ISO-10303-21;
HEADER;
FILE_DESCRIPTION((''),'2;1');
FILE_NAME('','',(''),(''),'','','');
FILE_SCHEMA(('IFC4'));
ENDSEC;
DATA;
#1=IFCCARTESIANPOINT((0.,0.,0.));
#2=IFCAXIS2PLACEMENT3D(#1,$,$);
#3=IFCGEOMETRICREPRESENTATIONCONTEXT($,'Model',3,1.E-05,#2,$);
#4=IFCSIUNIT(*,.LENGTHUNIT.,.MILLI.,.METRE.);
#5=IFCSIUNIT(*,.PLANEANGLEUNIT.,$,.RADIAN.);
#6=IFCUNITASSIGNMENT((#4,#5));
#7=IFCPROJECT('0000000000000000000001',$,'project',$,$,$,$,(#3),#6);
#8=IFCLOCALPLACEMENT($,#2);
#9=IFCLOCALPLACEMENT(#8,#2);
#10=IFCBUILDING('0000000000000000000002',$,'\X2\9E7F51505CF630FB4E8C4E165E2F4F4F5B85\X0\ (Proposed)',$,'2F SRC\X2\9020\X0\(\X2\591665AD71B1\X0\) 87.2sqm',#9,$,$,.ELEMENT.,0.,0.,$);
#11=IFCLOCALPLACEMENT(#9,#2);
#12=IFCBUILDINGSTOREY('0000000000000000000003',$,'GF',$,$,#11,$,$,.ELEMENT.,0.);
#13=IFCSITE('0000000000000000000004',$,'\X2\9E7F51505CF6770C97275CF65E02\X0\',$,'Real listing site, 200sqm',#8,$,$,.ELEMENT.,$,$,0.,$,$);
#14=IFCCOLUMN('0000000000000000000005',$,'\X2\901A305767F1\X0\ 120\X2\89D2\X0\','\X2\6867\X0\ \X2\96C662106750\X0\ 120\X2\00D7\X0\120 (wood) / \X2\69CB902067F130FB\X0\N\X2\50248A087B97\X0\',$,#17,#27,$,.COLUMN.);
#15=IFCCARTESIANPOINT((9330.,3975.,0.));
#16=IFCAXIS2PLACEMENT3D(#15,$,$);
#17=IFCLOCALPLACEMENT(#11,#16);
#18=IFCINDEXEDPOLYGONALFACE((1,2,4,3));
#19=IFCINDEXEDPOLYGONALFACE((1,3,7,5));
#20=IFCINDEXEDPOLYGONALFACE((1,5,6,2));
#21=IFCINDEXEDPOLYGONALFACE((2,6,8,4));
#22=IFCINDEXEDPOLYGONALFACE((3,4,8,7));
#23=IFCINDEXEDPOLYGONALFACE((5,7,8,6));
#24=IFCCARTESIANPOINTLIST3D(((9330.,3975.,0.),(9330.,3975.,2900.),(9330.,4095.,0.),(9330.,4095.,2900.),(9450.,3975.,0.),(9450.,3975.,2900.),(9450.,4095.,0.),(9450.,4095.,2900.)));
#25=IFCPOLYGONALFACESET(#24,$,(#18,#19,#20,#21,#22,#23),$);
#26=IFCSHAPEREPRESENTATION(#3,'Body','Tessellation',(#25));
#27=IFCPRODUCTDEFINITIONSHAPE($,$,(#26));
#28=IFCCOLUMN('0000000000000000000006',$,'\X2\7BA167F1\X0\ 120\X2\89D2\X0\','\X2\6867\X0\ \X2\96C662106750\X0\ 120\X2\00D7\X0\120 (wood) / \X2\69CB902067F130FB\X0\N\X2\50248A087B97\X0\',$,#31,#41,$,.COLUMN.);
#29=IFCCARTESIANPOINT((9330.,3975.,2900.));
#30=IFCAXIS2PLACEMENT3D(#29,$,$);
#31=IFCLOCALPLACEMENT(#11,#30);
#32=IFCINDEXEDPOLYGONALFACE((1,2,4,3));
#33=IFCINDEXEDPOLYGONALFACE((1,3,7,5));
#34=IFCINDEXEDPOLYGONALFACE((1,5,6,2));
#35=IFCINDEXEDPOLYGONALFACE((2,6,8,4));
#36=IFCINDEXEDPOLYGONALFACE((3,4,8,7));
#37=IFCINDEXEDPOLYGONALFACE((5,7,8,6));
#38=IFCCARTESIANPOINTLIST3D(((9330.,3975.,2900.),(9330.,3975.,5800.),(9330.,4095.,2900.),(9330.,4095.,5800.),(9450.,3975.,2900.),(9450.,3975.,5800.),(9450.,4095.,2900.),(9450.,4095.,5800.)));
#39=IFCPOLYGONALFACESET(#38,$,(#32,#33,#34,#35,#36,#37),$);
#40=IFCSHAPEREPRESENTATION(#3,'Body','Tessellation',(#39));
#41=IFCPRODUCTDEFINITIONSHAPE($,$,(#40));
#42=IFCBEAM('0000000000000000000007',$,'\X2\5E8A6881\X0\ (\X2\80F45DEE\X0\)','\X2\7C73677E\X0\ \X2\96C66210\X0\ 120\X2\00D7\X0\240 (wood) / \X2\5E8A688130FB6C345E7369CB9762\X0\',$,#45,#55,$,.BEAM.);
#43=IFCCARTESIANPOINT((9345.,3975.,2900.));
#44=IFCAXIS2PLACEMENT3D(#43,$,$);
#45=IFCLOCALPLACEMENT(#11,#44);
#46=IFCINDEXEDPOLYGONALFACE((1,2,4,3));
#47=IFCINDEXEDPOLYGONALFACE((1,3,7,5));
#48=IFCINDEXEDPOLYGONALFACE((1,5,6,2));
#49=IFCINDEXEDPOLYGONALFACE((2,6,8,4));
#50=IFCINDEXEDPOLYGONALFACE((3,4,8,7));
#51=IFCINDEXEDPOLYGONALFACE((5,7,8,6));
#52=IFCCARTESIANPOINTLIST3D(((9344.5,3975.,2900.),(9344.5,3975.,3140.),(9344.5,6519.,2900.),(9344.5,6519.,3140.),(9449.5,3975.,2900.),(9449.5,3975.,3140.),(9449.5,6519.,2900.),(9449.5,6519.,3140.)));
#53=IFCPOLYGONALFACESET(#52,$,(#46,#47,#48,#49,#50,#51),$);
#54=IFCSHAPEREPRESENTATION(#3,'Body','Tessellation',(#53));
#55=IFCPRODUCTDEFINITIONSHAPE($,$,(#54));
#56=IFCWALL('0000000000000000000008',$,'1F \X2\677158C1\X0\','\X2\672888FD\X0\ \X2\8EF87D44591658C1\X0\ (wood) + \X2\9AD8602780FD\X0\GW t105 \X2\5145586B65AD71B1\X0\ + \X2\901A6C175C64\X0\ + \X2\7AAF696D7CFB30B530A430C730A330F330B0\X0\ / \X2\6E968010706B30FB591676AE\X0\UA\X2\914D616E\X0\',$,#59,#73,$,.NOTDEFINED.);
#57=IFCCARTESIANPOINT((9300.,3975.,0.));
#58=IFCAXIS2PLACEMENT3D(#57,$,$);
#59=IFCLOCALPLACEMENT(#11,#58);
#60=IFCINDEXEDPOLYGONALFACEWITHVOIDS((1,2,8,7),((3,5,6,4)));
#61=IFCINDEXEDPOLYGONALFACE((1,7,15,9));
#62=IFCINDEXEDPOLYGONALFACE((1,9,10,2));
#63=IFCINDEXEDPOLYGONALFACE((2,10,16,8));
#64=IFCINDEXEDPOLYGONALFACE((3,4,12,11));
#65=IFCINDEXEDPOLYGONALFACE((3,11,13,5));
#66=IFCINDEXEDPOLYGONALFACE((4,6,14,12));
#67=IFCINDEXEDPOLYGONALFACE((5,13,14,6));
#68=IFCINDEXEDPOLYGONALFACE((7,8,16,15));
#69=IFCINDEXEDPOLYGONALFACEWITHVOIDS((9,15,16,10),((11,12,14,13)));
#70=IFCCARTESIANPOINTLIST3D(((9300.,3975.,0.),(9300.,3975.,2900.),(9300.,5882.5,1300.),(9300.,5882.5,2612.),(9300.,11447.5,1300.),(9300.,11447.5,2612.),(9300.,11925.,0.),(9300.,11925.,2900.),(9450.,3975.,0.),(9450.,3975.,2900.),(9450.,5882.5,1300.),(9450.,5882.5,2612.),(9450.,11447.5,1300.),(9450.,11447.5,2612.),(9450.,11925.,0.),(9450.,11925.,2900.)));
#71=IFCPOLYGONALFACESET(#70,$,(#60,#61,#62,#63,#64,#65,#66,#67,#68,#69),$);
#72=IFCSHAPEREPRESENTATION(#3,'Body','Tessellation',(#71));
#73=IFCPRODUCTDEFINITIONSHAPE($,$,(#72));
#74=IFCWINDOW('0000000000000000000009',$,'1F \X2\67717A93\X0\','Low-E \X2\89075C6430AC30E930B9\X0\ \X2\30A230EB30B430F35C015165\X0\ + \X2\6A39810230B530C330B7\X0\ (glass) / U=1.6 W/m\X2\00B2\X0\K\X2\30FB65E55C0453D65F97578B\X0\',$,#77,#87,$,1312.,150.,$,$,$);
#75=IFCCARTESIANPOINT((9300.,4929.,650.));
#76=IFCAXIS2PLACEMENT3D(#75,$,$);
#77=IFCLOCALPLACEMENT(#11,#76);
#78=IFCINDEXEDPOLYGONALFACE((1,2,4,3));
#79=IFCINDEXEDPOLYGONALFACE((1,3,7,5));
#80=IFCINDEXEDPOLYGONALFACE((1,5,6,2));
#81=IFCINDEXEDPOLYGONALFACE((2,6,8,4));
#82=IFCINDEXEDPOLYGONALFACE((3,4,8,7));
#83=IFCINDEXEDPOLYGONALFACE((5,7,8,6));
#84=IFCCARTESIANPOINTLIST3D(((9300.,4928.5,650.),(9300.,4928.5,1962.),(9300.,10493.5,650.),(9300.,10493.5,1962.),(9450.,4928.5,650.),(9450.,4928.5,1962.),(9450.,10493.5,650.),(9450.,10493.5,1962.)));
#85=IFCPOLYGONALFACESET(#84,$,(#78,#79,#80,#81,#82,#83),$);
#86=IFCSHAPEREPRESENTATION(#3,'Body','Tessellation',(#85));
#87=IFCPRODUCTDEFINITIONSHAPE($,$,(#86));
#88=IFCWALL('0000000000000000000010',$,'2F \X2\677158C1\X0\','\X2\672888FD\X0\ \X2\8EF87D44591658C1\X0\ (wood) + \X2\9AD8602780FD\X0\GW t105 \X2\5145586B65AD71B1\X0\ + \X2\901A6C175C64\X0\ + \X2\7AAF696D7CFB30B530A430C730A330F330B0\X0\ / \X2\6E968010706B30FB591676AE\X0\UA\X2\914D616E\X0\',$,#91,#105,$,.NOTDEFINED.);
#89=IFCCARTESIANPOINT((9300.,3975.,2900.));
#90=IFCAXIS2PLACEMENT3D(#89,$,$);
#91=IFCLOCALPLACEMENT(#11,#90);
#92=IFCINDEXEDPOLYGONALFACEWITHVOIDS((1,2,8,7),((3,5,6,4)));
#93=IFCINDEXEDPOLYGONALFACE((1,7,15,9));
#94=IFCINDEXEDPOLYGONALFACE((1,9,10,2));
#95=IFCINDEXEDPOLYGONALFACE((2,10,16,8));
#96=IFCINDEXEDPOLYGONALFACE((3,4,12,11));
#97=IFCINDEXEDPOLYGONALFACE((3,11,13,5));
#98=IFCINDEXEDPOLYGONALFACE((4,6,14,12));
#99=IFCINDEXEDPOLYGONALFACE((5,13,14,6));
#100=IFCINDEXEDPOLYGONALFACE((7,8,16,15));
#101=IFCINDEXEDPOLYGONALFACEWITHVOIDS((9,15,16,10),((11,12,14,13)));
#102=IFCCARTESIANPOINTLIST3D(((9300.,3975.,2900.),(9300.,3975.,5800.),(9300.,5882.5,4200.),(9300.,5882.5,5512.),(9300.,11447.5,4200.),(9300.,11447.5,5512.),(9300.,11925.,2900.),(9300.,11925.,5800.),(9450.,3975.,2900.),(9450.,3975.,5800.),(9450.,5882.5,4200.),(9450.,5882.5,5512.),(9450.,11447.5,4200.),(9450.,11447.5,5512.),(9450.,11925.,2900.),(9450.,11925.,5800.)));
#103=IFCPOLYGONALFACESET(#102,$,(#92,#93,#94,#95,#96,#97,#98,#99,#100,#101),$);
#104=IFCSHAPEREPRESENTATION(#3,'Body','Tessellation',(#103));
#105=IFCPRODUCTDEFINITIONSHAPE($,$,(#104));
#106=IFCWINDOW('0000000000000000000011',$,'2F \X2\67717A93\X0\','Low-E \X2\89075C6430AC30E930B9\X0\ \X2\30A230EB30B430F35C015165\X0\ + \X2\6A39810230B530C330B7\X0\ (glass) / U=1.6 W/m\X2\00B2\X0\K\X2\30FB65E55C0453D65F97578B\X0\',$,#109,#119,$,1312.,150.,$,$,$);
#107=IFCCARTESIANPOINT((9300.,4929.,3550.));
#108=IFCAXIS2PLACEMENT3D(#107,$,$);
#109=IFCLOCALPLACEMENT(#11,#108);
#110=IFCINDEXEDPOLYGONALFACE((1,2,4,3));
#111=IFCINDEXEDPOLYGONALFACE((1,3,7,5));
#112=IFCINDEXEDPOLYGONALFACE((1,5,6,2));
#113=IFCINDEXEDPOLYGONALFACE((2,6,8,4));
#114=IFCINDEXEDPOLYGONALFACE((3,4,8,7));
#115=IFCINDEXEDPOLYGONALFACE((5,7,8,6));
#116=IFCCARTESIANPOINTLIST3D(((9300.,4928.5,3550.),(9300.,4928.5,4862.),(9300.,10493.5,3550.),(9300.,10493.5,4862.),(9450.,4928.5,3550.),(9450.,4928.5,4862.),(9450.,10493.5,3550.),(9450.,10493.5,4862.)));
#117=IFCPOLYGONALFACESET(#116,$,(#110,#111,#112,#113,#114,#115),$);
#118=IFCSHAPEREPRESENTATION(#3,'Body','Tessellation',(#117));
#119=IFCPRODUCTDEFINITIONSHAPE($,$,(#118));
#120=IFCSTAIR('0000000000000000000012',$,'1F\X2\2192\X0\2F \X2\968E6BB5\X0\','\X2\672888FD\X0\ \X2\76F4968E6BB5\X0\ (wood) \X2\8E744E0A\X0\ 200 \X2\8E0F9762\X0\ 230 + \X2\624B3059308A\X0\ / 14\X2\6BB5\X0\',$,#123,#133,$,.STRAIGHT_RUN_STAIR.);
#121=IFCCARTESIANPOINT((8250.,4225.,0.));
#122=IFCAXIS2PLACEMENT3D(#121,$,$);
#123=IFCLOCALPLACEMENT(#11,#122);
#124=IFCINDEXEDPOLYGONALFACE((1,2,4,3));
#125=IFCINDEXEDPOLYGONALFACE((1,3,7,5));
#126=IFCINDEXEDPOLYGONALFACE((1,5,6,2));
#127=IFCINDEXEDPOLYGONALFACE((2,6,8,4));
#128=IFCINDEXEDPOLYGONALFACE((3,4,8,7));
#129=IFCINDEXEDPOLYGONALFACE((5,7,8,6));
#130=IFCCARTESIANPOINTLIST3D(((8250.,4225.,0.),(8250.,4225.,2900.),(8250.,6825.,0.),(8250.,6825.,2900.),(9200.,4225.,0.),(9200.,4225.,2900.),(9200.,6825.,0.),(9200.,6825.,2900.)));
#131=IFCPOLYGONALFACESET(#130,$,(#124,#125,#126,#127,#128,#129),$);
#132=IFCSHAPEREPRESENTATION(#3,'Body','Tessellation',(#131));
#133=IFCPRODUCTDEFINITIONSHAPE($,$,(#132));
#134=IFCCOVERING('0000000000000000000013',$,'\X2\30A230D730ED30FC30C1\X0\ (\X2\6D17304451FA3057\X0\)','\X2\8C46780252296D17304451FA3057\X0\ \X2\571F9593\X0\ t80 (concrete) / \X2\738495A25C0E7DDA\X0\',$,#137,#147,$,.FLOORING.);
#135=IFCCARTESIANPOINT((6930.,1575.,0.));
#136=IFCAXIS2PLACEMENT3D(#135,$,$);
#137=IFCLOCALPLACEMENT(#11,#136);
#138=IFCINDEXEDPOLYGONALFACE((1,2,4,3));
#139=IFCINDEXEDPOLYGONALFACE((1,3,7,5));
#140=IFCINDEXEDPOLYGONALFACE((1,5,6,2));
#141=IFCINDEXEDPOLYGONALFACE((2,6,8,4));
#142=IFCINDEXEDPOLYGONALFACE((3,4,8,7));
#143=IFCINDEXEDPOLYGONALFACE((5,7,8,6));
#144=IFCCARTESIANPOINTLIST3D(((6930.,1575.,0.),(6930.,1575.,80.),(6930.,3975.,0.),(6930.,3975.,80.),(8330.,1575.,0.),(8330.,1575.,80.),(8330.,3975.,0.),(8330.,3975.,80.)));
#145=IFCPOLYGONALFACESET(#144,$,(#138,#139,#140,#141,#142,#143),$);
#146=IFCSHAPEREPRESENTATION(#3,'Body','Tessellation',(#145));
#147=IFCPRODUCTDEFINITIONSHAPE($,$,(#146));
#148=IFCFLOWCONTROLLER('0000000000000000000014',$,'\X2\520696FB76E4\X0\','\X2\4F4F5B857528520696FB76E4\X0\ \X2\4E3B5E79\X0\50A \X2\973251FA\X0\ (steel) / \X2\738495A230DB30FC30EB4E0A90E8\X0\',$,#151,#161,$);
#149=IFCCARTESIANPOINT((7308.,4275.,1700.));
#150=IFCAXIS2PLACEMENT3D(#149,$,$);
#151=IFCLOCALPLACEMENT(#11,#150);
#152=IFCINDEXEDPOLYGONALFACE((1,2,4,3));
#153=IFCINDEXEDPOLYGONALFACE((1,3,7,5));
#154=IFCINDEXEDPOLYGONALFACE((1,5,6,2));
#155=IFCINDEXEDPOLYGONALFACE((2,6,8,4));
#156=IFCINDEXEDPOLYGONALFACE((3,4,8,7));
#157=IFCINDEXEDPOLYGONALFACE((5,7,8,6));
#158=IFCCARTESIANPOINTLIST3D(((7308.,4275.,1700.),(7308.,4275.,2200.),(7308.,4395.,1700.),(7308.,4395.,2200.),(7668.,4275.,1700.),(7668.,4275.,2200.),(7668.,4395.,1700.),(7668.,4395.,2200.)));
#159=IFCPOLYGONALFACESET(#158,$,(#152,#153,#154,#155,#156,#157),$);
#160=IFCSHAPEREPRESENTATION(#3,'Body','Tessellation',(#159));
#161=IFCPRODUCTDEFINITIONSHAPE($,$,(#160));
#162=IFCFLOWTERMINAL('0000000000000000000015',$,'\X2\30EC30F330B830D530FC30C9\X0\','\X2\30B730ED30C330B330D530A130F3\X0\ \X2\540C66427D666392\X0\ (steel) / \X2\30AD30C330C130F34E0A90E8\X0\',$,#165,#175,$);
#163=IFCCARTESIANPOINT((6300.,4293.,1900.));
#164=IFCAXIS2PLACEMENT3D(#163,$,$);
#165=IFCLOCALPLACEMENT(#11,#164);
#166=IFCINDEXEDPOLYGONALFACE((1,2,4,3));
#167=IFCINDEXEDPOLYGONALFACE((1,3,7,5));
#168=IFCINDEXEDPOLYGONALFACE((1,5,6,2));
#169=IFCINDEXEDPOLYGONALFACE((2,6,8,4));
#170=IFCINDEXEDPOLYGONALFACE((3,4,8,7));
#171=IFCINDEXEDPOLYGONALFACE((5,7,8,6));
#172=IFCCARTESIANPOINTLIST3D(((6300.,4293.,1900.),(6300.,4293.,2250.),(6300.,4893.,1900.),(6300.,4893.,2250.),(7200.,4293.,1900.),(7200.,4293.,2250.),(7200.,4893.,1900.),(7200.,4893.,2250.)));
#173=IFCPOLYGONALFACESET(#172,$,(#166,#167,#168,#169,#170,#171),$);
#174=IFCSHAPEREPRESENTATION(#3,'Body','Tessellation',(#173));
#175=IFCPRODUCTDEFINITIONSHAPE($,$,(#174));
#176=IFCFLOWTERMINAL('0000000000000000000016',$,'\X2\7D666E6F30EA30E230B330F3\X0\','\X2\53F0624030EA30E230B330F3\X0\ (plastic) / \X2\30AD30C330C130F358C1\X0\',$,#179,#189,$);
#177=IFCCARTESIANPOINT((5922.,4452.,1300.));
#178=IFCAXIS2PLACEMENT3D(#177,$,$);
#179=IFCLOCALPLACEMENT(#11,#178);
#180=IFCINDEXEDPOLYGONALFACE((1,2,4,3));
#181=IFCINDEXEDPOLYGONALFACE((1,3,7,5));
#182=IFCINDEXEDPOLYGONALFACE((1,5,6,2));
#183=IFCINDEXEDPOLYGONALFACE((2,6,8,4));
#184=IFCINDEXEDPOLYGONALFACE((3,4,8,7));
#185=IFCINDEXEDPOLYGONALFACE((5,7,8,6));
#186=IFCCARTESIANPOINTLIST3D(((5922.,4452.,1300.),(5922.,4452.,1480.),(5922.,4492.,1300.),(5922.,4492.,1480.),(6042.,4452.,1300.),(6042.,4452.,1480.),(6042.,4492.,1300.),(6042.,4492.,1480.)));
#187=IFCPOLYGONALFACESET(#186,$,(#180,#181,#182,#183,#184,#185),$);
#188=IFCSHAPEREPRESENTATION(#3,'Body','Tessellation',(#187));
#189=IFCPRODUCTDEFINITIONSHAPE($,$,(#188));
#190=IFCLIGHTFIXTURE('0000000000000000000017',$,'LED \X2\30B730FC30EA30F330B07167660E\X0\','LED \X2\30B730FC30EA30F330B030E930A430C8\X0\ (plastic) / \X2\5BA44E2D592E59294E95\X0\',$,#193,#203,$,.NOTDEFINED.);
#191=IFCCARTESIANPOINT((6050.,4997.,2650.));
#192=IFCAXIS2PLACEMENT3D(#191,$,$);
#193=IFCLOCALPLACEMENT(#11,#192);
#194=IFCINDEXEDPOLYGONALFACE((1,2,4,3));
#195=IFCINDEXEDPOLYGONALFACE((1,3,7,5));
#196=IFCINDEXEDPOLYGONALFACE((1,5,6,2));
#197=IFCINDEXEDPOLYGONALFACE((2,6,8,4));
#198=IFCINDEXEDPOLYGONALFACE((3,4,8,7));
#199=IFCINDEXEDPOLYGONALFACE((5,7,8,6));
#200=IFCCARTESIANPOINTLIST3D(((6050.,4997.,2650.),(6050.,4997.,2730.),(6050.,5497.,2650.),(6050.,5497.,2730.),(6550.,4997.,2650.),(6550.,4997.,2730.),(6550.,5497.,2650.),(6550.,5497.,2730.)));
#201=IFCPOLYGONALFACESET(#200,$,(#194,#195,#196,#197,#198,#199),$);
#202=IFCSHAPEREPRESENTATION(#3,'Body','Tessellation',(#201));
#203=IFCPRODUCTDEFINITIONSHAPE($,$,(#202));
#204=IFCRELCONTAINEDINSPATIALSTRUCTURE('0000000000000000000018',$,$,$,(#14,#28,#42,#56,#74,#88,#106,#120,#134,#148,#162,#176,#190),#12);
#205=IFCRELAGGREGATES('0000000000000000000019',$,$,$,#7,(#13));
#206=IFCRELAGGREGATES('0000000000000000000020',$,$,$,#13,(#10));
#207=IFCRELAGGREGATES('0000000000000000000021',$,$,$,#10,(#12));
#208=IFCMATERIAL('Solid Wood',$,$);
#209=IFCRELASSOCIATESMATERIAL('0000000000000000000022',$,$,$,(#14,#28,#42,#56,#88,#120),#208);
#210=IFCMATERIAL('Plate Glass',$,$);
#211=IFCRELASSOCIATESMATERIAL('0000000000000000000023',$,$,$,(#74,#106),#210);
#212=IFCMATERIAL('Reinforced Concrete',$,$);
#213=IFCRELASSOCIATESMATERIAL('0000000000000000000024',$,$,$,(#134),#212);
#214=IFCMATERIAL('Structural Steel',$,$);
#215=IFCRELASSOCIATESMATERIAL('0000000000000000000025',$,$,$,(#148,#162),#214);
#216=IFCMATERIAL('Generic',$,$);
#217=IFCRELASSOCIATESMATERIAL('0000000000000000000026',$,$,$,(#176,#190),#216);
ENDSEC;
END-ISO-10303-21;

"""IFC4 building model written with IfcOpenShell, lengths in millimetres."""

from ifc_helpers import new_model, si_unit, frame, frame_2d, origin, place, context, project, spatial, rectangle, extrude, material, element, fill, save


model = new_model("IFC4")

# Units and contexts
model_context = context("Model", 3, precision=1e-05, world=origin())
ifc_project = project(units=[si_unit("LENGTHUNIT", "METRE", prefix="MILLI"), si_unit("PLANEANGLEUNIT", "RADIAN")], contexts=[model_context])

# Site, building, storey
site_placement = place(None, origin())
site = spatial("IfcSite", under=ifc_project, at=site_placement, Name="鹿児島県霧島市", ObjectType="Real listing site, 200sqm", CompositionType="ELEMENT", RefElevation=0.0)
building_placement = place(site_placement, origin())
building = spatial("IfcBuilding", under=site, at=building_placement, Name="鹿児島・二世帯住宅 (Proposed)", ObjectType="2F SRC造(外断熱) 87.2sqm", CompositionType="ELEMENT", ElevationOfRefHeight=0.0, ElevationOfTerrain=0.0)
storey_placement = place(building_placement, origin())
storey = spatial("IfcBuildingStorey", under=building, at=storey_placement, Name="GF", CompositionType="ELEMENT", Elevation=0.0)

# Columns
ifc_material_1 = material(Name="Solid Wood")
column_1_placement = place(storey_placement, frame((9330.0, 3975.0, 0.0)))
element("IfcColumn", 1, at=column_1_placement, inside=storey, material=ifc_material_1, Name="通し柱 120角", Description="桧 集成材 120×120 (wood) / 構造柱・N値計算", PredefinedType="COLUMN", context=model_context, shape_type="SweptSolid", body=[
    extrude(rectangle(XDim=120.0, YDim=120.0, at=frame_2d((60.0, 60.0))), frame((9330.0, 3975.0, 0.0)), (0.0, 0.0, 1.0), 2900.0),
])
column_2_placement = place(storey_placement, frame((9330.0, 3975.0, 2900.0)))
element("IfcColumn", 2, at=column_2_placement, inside=storey, material=ifc_material_1, Name="管柱 120角", Description="桧 集成材 120×120 (wood) / 構造柱・N値計算", PredefinedType="COLUMN", context=model_context, shape_type="SweptSolid", body=[
    extrude(rectangle(XDim=120.0, YDim=120.0, at=frame_2d((60.0, 60.0))), frame((9330.0, 3975.0, 2900.0)), (0.0, 0.0, 1.0), 2900.0),
])

# Beam
beam_1_placement = place(storey_placement, frame((9345.0, 3975.0, 2900.0)))
element("IfcBeam", 3, at=beam_1_placement, inside=storey, material=ifc_material_1, Name="床梁 (胴差)", Description="米松 集成 120×240 (wood) / 床梁・水平構面", PredefinedType="BEAM", context=model_context, shape_type="SweptSolid", body=[
    extrude(rectangle(XDim=105.0, YDim=2544.0, at=frame_2d((52.0, 1272.0))), frame((9345.0, 3975.0, 2900.0)), (0.0, 0.0, 1.0), 240.0),
])

# Wall, opening, window
wall_1_placement = place(storey_placement, frame((9300.0, 3975.0, 0.0)))
wall_1 = element("IfcWall", 4, at=wall_1_placement, inside=storey, material=ifc_material_1, Name="1F 東壁", Description="木製 軸組外壁 (wood) + 高性能GW t105 充填断熱 + 通気層 + 窯業系サイディング / 準耐火・外皮UA配慮", PredefinedType="NOTDEFINED", context=model_context, shape_type="SweptSolid", body=[
    extrude(rectangle(XDim=150.0, YDim=7950.0, at=frame_2d((75.0, 3975.0))), frame((9300.0, 3975.0, 0.0)), (0.0, 0.0, 1.0), 2900.0),
])
opening_1_placement = place(storey_placement, frame((9300.0, 4929.0, 650.0)))
opening_1 = element("IfcOpeningElement", 5, at=opening_1_placement, cuts=wall_1, PredefinedType="NOTDEFINED", context=model_context, shape_type="SweptSolid", body=[
    extrude(rectangle(XDim=150.0, YDim=5565.0, at=frame_2d((75.0, 2782.0))), frame((9300.0, 4929.0, 650.0)), (0.0, 0.0, 1.0), 1312.0),
])
ifc_material_2 = material(Name="Plate Glass")
window_1_placement = place(storey_placement, frame((9300.0, 4929.0, 650.0)))
window_1 = element("IfcWindow", 6, at=window_1_placement, inside=storey, material=ifc_material_2, Name="1F 東窓", Description="Low-E 複層ガラス アルゴン封入 + 樹脂サッシ (glass) / U=1.6 W/m²K・日射取得型", OverallHeight=1312.0, OverallWidth=150.0, context=model_context, shape_type="SweptSolid", body=[
    extrude(rectangle(XDim=150.0, YDim=5565.0, at=frame_2d((75.0, 2782.0))), frame((9300.0, 4929.0, 650.0)), (0.0, 0.0, 1.0), 1312.0),
])
fill(opening_1, window_1)

# Wall, opening, window
wall_2_placement = place(storey_placement, frame((9300.0, 3975.0, 2900.0)))
wall_2 = element("IfcWall", 7, at=wall_2_placement, inside=storey, material=ifc_material_1, Name="2F 東壁", Description="木製 軸組外壁 (wood) + 高性能GW t105 充填断熱 + 通気層 + 窯業系サイディング / 準耐火・外皮UA配慮", PredefinedType="NOTDEFINED", context=model_context, shape_type="SweptSolid", body=[
    extrude(rectangle(XDim=150.0, YDim=7950.0, at=frame_2d((75.0, 3975.0))), frame((9300.0, 3975.0, 2900.0)), (0.0, 0.0, 1.0), 2900.0),
])
opening_2_placement = place(storey_placement, frame((9300.0, 4929.0, 3550.0)))
opening_2 = element("IfcOpeningElement", 8, at=opening_2_placement, cuts=wall_2, PredefinedType="NOTDEFINED", context=model_context, shape_type="SweptSolid", body=[
    extrude(rectangle(XDim=150.0, YDim=5565.0, at=frame_2d((75.0, 2782.0))), frame((9300.0, 4929.0, 3550.0)), (0.0, 0.0, 1.0), 1312.0),
])
window_2_placement = place(storey_placement, frame((9300.0, 4929.0, 3550.0)))
window_2 = element("IfcWindow", 9, at=window_2_placement, inside=storey, material=ifc_material_2, Name="2F 東窓", Description="Low-E 複層ガラス アルゴン封入 + 樹脂サッシ (glass) / U=1.6 W/m²K・日射取得型", OverallHeight=1312.0, OverallWidth=150.0, context=model_context, shape_type="SweptSolid", body=[
    extrude(rectangle(XDim=150.0, YDim=5565.0, at=frame_2d((75.0, 2782.0))), frame((9300.0, 4929.0, 3550.0)), (0.0, 0.0, 1.0), 1312.0),
])
fill(opening_2, window_2)

# Stair
stair_placement = place(storey_placement, frame((8250.0, 4225.0, 0.0)))
element("IfcStair", 10, at=stair_placement, inside=storey, material=ifc_material_1, Name="1F→2F 階段", Description="木製 直階段 (wood) 蹴上 200 踏面 230 + 手すり / 14段", PredefinedType="STRAIGHT_RUN_STAIR", context=model_context, shape_type="SweptSolid", body=[
    extrude(rectangle(XDim=950.0, YDim=2600.0, at=frame_2d((475.0, 1300.0))), frame((8250.0, 4225.0, 0.0)), (0.0, 0.0, 1.0), 2900.0),
])

# Covering
ifc_material_3 = material(Name="Reinforced Concrete")
covering_placement = place(storey_placement, frame((6930.0, 1575.0, 0.0)))
element("IfcCovering", 11, at=covering_placement, inside=storey, material=ifc_material_3, Name="アプローチ (洗い出し)", Description="豆砂利洗い出し 土間 t80 (concrete) / 玄関導線", PredefinedType="FLOORING", context=model_context, shape_type="SweptSolid", body=[
    extrude(rectangle(XDim=1400.0, YDim=2400.0, at=frame_2d((700.0, 1200.0))), frame((6930.0, 1575.0, 0.0)), (0.0, 0.0, 1.0), 80.0),
])

# Flow controller
ifc_material_4 = material(Name="Structural Steel")
flow_controller_placement = place(storey_placement, frame((7308.0, 4275.0, 1700.0)))
element("IfcFlowController", 12, at=flow_controller_placement, inside=storey, material=ifc_material_4, Name="分電盤", Description="住宅用分電盤 主幹50A 露出 (steel) / 玄関ホール上部", context=model_context, shape_type="SweptSolid", body=[
    extrude(rectangle(XDim=360.0, YDim=120.0, at=frame_2d((180.0, 60.0))), frame((7308.0, 4275.0, 1700.0)), (0.0, 0.0, 1.0), 500.0),
])

# Flow terminals
flow_terminal_1_placement = place(storey_placement, frame((6300.0, 4293.0, 1900.0)))
element("IfcFlowTerminal", 13, at=flow_terminal_1_placement, inside=storey, material=ifc_material_4, Name="レンジフード", Description="シロッコファン 同時給排 (steel) / キッチン上部", context=model_context, shape_type="SweptSolid", body=[
    extrude(rectangle(XDim=900.0, YDim=600.0, at=frame_2d((450.0, 300.0))), frame((6300.0, 4293.0, 1900.0)), (0.0, 0.0, 1.0), 350.0),
])
ifc_material_5 = material(Name="Generic")
flow_terminal_2_placement = place(storey_placement, frame((5922.0, 4452.0, 1300.0)))
element("IfcFlowTerminal", 14, at=flow_terminal_2_placement, inside=storey, material=ifc_material_5, Name="給湯リモコン", Description="台所リモコン (plastic) / キッチン壁", context=model_context, shape_type="SweptSolid", body=[
    extrude(rectangle(XDim=120.0, YDim=40.0, at=frame_2d((60.0, 20.0))), frame((5922.0, 4452.0, 1300.0)), (0.0, 0.0, 1.0), 180.0),
])

# Light fixture
light_fixture_1_placement = place(storey_placement, frame((6050.0, 4997.0, 2650.0)))
element("IfcLightFixture", 15, at=light_fixture_1_placement, inside=storey, material=ifc_material_5, Name="LED シーリング照明", Description="LED シーリングライト (plastic) / 室中央天井", PredefinedType="NOTDEFINED", context=model_context, shape_type="SweptSolid", body=[
    extrude(rectangle(XDim=500.0, YDim=500.0, at=frame_2d((250.0, 250.0))), frame((6050.0, 4997.0, 2650.0)), (0.0, 0.0, 1.0), 80.0),
])

save(model, "model.ifc")
